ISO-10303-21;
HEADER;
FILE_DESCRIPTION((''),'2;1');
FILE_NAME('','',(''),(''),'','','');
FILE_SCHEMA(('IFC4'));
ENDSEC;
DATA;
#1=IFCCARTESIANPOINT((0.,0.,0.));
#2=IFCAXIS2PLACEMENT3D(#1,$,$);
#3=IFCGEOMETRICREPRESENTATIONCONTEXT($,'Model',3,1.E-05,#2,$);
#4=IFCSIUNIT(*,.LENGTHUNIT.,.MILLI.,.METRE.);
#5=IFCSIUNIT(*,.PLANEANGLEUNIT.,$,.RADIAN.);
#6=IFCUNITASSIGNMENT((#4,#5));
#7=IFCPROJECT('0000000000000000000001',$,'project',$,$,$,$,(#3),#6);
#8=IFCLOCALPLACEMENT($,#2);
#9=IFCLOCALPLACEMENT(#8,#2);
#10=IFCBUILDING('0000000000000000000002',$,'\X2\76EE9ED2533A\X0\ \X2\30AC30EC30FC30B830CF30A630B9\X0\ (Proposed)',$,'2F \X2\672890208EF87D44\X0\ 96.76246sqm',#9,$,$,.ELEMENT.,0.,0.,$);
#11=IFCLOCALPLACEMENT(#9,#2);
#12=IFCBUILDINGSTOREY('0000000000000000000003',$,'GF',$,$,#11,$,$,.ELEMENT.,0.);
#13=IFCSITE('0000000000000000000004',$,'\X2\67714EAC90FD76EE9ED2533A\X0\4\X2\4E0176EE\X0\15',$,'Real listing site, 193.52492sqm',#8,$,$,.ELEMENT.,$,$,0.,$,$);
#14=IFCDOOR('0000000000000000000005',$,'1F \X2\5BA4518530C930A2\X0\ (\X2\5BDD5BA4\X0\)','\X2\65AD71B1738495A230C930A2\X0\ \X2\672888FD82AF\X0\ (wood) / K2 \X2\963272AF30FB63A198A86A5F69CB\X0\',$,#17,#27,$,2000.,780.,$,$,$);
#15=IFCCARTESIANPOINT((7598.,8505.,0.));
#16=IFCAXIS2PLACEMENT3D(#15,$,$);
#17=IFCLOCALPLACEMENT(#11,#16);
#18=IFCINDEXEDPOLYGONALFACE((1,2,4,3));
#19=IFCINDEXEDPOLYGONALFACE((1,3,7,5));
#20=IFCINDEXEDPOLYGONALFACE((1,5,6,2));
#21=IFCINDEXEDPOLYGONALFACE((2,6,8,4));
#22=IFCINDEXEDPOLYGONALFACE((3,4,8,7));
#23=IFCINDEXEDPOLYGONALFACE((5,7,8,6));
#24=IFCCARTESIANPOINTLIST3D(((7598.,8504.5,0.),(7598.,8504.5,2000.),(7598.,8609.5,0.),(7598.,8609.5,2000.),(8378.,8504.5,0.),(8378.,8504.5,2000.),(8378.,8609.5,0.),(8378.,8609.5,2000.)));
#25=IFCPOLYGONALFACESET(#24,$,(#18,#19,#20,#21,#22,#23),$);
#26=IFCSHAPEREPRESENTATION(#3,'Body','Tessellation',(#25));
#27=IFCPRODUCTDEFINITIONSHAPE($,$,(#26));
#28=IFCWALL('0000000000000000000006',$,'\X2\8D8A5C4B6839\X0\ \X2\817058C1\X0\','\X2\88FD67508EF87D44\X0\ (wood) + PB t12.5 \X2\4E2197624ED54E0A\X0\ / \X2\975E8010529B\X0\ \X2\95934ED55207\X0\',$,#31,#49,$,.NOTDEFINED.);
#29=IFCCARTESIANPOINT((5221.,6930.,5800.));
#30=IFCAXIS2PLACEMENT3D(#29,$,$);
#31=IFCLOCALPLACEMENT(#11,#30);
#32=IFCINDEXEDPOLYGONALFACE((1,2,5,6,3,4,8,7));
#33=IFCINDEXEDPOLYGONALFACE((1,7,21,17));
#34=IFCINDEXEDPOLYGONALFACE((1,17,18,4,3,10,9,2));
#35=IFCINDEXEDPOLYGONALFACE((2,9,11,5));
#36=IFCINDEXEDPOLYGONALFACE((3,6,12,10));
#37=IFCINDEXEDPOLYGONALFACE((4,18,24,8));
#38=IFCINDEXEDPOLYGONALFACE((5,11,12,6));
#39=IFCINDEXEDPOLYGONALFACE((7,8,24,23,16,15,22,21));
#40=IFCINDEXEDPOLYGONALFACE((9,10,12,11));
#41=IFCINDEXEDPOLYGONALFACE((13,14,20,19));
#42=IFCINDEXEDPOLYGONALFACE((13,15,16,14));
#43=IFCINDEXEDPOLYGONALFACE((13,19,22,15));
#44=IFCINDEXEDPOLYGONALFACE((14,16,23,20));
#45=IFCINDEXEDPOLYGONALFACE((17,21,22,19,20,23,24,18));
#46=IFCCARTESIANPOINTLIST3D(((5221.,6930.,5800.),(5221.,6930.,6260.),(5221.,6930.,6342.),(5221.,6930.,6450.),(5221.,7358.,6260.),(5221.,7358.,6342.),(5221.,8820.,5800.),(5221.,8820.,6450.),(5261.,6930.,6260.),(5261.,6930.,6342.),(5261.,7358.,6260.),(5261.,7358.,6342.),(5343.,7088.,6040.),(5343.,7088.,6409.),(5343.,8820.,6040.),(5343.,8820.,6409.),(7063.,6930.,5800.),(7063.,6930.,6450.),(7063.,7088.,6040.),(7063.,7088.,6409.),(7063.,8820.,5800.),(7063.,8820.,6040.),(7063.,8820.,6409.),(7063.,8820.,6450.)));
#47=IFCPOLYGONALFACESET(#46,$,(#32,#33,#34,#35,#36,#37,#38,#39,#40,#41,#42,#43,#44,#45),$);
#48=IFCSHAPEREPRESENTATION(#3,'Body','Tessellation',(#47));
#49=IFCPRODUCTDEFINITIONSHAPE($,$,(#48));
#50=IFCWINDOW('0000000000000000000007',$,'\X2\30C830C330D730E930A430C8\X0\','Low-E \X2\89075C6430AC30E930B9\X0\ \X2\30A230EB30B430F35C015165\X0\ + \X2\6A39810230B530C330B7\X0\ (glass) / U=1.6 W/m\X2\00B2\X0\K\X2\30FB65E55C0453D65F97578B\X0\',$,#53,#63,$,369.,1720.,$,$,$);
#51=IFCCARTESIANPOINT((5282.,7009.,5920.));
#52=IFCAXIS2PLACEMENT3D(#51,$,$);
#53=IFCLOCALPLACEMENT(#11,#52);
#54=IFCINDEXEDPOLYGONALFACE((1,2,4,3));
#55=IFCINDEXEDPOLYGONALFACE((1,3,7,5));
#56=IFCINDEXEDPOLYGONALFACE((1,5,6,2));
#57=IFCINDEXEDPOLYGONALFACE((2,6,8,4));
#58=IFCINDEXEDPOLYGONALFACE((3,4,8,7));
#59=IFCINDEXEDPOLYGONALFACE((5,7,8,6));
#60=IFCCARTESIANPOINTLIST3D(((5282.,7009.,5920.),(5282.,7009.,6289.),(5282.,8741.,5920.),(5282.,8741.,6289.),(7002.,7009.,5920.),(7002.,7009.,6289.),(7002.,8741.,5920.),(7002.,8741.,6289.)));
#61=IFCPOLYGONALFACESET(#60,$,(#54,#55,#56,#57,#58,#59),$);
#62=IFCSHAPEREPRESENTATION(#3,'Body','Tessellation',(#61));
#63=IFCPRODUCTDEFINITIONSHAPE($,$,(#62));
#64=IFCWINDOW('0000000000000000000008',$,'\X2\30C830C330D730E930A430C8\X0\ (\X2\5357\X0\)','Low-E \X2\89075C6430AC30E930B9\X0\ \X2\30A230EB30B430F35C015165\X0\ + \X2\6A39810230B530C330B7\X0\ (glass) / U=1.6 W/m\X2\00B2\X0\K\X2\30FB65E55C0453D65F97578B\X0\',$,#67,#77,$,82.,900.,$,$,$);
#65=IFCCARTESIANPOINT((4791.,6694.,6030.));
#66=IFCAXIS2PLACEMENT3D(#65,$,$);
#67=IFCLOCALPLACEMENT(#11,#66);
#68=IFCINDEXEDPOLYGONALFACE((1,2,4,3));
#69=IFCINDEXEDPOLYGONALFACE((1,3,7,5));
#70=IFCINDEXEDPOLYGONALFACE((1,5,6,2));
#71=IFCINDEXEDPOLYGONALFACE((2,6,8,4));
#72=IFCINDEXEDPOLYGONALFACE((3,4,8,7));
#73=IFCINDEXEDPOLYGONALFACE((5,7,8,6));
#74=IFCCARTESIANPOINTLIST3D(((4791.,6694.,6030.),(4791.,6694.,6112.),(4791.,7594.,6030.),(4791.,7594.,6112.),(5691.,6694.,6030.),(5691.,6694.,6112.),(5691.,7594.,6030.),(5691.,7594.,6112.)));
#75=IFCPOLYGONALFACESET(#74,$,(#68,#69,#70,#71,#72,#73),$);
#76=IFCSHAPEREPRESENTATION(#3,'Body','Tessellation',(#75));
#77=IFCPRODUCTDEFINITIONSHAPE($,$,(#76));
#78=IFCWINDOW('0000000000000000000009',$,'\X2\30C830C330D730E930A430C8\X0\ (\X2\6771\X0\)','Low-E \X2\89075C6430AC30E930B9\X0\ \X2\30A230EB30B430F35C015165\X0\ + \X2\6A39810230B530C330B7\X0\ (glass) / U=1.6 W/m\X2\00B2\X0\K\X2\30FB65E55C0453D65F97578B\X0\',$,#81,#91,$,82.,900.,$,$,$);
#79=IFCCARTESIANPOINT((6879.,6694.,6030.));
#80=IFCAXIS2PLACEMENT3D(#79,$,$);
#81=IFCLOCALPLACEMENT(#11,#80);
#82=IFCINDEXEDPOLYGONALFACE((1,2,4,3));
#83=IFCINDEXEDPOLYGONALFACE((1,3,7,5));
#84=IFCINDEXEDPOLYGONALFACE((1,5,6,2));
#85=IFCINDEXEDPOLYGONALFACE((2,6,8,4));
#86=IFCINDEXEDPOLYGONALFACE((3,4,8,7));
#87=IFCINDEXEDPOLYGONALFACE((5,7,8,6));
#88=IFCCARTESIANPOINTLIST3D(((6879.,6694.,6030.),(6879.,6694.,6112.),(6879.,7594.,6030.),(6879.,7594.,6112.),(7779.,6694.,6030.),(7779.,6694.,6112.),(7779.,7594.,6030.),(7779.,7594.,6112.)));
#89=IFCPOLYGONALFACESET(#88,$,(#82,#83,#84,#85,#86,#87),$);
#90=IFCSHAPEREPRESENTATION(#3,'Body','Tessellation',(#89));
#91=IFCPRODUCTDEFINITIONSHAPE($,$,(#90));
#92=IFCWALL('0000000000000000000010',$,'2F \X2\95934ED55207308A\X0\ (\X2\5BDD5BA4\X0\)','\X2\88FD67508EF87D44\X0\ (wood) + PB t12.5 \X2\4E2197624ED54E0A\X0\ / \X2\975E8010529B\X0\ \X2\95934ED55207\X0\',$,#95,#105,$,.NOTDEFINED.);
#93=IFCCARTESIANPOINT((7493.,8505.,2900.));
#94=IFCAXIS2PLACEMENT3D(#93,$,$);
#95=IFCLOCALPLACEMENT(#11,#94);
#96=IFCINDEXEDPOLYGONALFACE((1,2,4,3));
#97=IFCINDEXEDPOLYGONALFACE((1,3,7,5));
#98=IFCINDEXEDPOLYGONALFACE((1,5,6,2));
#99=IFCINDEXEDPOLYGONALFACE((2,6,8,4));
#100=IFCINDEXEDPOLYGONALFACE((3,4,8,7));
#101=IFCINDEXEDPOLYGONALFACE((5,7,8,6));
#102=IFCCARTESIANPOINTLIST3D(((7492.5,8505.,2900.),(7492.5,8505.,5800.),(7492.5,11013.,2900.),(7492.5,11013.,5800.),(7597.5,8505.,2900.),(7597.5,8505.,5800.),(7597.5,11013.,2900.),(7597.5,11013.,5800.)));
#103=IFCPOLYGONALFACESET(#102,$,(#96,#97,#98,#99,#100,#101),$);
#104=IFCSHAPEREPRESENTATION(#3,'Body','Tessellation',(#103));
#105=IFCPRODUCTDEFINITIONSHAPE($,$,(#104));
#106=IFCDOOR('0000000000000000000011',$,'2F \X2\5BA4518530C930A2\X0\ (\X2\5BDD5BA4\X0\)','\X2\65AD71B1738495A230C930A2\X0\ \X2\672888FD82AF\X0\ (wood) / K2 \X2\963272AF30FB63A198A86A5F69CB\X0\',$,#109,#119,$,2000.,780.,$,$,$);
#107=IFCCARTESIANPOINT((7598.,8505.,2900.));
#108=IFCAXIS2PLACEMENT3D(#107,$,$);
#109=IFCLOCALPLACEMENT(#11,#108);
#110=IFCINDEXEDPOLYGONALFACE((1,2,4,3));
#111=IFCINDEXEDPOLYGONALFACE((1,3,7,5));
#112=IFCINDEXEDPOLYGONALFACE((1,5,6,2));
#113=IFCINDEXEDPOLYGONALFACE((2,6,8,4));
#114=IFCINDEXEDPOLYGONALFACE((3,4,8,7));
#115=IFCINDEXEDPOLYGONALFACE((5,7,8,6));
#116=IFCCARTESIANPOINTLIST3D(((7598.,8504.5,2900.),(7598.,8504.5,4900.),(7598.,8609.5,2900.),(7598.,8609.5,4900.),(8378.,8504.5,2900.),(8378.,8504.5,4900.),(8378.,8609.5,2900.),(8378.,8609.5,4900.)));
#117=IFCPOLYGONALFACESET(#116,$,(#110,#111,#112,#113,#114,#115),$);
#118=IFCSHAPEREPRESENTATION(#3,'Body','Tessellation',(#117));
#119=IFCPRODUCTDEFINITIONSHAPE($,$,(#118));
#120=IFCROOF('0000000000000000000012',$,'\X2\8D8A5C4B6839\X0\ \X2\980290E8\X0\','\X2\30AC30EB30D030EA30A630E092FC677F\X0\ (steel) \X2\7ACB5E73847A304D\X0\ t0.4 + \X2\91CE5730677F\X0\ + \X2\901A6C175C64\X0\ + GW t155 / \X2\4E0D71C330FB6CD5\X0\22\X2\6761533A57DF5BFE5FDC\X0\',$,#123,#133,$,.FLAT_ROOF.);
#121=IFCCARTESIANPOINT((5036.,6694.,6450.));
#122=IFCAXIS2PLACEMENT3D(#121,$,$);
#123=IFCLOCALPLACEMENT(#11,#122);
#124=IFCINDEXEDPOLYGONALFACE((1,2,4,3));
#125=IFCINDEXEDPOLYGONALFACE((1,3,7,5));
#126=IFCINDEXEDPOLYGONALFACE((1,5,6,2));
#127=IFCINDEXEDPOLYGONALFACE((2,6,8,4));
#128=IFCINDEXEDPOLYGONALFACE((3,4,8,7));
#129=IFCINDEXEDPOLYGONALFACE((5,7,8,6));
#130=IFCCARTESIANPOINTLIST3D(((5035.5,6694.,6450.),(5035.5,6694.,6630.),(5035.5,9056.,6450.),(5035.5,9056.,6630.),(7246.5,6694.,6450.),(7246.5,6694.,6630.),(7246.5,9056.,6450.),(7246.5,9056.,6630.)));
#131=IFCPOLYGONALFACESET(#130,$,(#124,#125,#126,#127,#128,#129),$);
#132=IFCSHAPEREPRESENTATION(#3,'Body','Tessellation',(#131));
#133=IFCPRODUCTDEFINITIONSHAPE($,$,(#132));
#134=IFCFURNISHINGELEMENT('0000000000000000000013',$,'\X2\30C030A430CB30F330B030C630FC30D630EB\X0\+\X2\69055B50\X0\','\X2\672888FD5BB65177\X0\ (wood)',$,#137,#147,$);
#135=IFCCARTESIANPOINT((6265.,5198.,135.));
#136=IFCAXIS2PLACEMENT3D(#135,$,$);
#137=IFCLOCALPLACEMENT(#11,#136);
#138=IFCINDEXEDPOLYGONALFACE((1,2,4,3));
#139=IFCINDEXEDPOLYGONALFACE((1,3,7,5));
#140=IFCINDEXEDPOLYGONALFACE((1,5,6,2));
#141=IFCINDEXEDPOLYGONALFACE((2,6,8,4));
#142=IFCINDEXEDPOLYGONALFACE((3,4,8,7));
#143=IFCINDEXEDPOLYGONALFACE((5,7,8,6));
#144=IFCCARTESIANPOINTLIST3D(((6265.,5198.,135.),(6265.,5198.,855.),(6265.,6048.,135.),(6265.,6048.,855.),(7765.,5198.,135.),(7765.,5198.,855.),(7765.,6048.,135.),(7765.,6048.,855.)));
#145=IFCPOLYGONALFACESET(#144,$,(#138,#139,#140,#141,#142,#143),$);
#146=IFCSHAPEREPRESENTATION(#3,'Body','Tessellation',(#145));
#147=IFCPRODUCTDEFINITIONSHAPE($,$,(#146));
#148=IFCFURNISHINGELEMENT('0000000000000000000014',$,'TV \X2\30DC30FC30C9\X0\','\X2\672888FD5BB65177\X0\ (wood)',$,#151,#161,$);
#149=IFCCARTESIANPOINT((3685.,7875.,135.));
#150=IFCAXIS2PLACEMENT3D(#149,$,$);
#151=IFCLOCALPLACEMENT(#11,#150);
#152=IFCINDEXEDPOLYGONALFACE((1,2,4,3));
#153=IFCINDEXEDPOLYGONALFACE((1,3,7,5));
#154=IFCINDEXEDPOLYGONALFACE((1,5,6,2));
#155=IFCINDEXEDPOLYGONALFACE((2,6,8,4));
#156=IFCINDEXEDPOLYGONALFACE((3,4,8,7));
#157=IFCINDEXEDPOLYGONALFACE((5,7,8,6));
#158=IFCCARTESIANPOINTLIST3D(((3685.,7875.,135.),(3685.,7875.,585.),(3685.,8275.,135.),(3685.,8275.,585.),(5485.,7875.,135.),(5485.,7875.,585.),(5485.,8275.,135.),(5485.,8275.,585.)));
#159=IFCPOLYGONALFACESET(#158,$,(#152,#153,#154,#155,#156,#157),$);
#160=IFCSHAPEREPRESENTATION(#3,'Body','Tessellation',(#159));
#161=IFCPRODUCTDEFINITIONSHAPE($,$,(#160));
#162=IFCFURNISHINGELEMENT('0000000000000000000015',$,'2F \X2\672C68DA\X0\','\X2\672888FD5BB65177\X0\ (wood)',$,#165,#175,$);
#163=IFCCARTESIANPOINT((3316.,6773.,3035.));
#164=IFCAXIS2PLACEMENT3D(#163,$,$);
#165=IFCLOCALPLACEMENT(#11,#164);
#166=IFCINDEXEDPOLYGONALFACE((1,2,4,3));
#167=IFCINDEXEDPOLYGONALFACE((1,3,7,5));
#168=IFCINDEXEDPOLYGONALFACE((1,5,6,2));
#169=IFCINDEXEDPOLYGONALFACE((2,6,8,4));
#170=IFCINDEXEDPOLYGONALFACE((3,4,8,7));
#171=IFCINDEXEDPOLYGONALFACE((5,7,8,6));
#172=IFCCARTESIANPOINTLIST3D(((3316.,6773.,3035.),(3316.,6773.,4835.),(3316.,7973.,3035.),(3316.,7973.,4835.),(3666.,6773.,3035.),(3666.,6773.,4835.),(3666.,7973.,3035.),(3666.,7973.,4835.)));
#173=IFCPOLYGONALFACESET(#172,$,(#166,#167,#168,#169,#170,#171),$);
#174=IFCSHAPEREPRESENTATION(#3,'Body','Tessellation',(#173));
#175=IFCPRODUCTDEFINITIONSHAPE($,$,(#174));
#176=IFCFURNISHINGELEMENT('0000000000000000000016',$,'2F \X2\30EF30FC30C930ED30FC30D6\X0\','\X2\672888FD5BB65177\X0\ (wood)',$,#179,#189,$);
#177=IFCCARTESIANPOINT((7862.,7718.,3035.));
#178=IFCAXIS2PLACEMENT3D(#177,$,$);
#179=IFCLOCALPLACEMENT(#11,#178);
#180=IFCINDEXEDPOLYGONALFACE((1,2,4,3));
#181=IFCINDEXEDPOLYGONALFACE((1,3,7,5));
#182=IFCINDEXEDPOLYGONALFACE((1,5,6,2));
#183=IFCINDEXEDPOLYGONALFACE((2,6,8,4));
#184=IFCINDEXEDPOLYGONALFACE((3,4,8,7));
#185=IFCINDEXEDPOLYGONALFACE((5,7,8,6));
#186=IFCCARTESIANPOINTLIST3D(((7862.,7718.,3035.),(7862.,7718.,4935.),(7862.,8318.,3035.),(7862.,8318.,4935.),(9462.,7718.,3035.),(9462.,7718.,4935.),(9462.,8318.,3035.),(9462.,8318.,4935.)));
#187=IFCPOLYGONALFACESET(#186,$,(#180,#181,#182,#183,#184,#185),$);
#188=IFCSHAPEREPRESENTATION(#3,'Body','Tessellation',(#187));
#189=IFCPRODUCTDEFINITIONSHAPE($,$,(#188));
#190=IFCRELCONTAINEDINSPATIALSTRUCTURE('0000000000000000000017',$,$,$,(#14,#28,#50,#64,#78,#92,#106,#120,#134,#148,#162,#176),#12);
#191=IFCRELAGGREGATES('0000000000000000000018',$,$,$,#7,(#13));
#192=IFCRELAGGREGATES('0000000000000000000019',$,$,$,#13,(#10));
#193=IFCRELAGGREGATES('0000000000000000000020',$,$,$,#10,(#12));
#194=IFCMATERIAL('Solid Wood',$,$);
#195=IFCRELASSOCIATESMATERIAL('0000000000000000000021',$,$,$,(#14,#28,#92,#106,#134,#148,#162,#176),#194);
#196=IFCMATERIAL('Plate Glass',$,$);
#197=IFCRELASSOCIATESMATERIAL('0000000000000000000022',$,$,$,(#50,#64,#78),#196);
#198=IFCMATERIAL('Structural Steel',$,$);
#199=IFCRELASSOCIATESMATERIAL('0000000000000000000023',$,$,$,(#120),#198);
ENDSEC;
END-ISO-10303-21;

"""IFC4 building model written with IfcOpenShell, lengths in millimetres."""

from ifc_helpers import new_model, si_unit, frame, frame_2d, origin, place, context, project, spatial, rectangle, extrude, material, element, fill, save


model = new_model("IFC4")

# Units and contexts
model_context = context("Model", 3, precision=1e-05, world=origin())
ifc_project = project(units=[si_unit("LENGTHUNIT", "METRE", prefix="MILLI"), si_unit("PLANEANGLEUNIT", "RADIAN")], contexts=[model_context])

# Site, building, storey
site_placement = place(None, origin())
site = spatial("IfcSite", under=ifc_project, at=site_placement, Name="東京都目黒区4丁目15", ObjectType="Real listing site, 193.52492sqm", CompositionType="ELEMENT", RefElevation=0.0)
building_placement = place(site_placement, origin())
building = spatial("IfcBuilding", under=site, at=building_placement, Name="目黒区 ガレージハウス (Proposed)", ObjectType="2F 木造軸組 96.76246sqm", CompositionType="ELEMENT", ElevationOfRefHeight=0.0, ElevationOfTerrain=0.0)
storey_placement = place(building_placement, origin())
storey = spatial("IfcBuildingStorey", under=building, at=storey_placement, Name="GF", CompositionType="ELEMENT", Elevation=0.0)

# Shared definitions
ifc_material_1 = material(Name="Solid Wood")

# Door
door_1_placement = place(storey_placement, frame((7598.0, 8505.0, 0.0)))
element("IfcDoor", 1, at=door_1_placement, inside=storey, material=ifc_material_1, Name="1F 室内ドア (寝室)", Description="断熱玄関ドア 木製芯 (wood) / K2 防犯・採風機構", OverallHeight=2000.0, OverallWidth=780.0, context=model_context, shape_type="SweptSolid", body=[
    extrude(rectangle(XDim=780.0, YDim=105.0, at=frame_2d((390.0, 52.0))), frame((7598.0, 8505.0, 0.0)), (0.0, 0.0, 1.0), 2000.0),
])

# Wall, openings, windows
wall_1_placement = place(storey_placement, frame((5221.0, 6930.0, 5800.0)))
wall_1 = element("IfcWall", 2, at=wall_1_placement, inside=storey, material=ifc_material_1, Name="越屋根 腰壁", Description="製材軸組 (wood) + PB t12.5 両面仕上 / 非耐力 間仕切", PredefinedType="NOTDEFINED", context=model_context, shape_type="SweptSolid", body=[
    extrude(rectangle(XDim=1842.0, YDim=1890.0, at=frame_2d((921.0, 945.0))), frame((5221.0, 6930.0, 5800.0)), (0.0, 0.0, 1.0), 650.0),
])
opening_1_placement = place(storey_placement, frame((5282.0, 7009.0, 5920.0)))
opening_1 = element("IfcOpeningElement", 3, at=opening_1_placement, cuts=wall_1, PredefinedType="NOTDEFINED", context=model_context, shape_type="SweptSolid", body=[
    extrude(rectangle(XDim=1720.0, YDim=1732.0, at=frame_2d((860.0, 866.0))), frame((5282.0, 7009.0, 5920.0)), (0.0, 0.0, 1.0), 369.0),
])
opening_2_placement = place(storey_placement, frame((4791.0, 6694.0, 6030.0)))
opening_2 = element("IfcOpeningElement", 4, at=opening_2_placement, cuts=wall_1, PredefinedType="NOTDEFINED", context=model_context, shape_type="SweptSolid", body=[
    extrude(rectangle(XDim=900.0, YDim=900.0, at=frame_2d((450.0, 450.0))), frame((4791.0, 6694.0, 6030.0)), (0.0, 0.0, 1.0), 82.0),
])
opening_3_placement = place(storey_placement, frame((6879.0, 6694.0, 6030.0)))
opening_3 = element("IfcOpeningElement", 5, at=opening_3_placement, cuts=wall_1, PredefinedType="NOTDEFINED", context=model_context, shape_type="SweptSolid", body=[
    extrude(rectangle(XDim=900.0, YDim=900.0, at=frame_2d((450.0, 450.0))), frame((6879.0, 6694.0, 6030.0)), (0.0, 0.0, 1.0), 82.0),
])
ifc_material_2 = material(Name="Plate Glass")
window_1_placement = place(storey_placement, frame((5282.0, 7009.0, 5920.0)))
window_1 = element("IfcWindow", 6, at=window_1_placement, inside=storey, material=ifc_material_2, Name="トップライト", Description="Low-E 複層ガラス アルゴン封入 + 樹脂サッシ (glass) / U=1.6 W/m²K・日射取得型", OverallHeight=369.0, OverallWidth=1720.0, context=model_context, shape_type="SweptSolid", body=[
    extrude(rectangle(XDim=1720.0, YDim=1732.0, at=frame_2d((860.0, 866.0))), frame((5282.0, 7009.0, 5920.0)), (0.0, 0.0, 1.0), 369.0),
])
fill(opening_1, window_1)
window_2_placement = place(storey_placement, frame((4791.0, 6694.0, 6030.0)))
window_2 = element("IfcWindow", 7, at=window_2_placement, inside=storey, material=ifc_material_2, Name="トップライト (南)", Description="Low-E 複層ガラス アルゴン封入 + 樹脂サッシ (glass) / U=1.6 W/m²K・日射取得型", OverallHeight=82.0, OverallWidth=900.0, context=model_context, shape_type="SweptSolid", body=[
    extrude(rectangle(XDim=900.0, YDim=900.0, at=frame_2d((450.0, 450.0))), frame((4791.0, 6694.0, 6030.0)), (0.0, 0.0, 1.0), 82.0),
])
fill(opening_2, window_2)
window_3_placement = place(storey_placement, frame((6879.0, 6694.0, 6030.0)))
window_3 = element("IfcWindow", 8, at=window_3_placement, inside=storey, material=ifc_material_2, Name="トップライト (東)", Description="Low-E 複層ガラス アルゴン封入 + 樹脂サッシ (glass) / U=1.6 W/m²K・日射取得型", OverallHeight=82.0, OverallWidth=900.0, context=model_context, shape_type="SweptSolid", body=[
    extrude(rectangle(XDim=900.0, YDim=900.0, at=frame_2d((450.0, 450.0))), frame((6879.0, 6694.0, 6030.0)), (0.0, 0.0, 1.0), 82.0),
])
fill(opening_3, window_3)

# Wall
wall_2_placement = place(storey_placement, frame((7493.0, 8505.0, 2900.0)))
element("IfcWall", 9, at=wall_2_placement, inside=storey, material=ifc_material_1, Name="2F 間仕切り (寝室)", Description="製材軸組 (wood) + PB t12.5 両面仕上 / 非耐力 間仕切", PredefinedType="NOTDEFINED", context=model_context, shape_type="SweptSolid", body=[
    extrude(rectangle(XDim=105.0, YDim=2508.0, at=frame_2d((52.0, 1254.0))), frame((7493.0, 8505.0, 2900.0)), (0.0, 0.0, 1.0), 2900.0),
])

# Door
door_2_placement = place(storey_placement, frame((7598.0, 8505.0, 2900.0)))
element("IfcDoor", 10, at=door_2_placement, inside=storey, material=ifc_material_1, Name="2F 室内ドア (寝室)", Description="断熱玄関ドア 木製芯 (wood) / K2 防犯・採風機構", OverallHeight=2000.0, OverallWidth=780.0, context=model_context, shape_type="SweptSolid", body=[
    extrude(rectangle(XDim=780.0, YDim=105.0, at=frame_2d((390.0, 52.0))), frame((7598.0, 8505.0, 2900.0)), (0.0, 0.0, 1.0), 2000.0),
])

# Roof
ifc_material_3 = material(Name="Structural Steel")
roof_placement = place(storey_placement, frame((5036.0, 6694.0, 6450.0)))
element("IfcRoof", 11, at=roof_placement, inside=storey, material=ifc_material_3, Name="越屋根 頂部", Description="ガルバリウム鋼板 (steel) 立平葺き t0.4 + 野地板 + 通気層 + GW t155 / 不燃・法22条区域対応", PredefinedType="FLAT_ROOF", context=model_context, shape_type="SweptSolid", body=[
    extrude(rectangle(XDim=2211.0, YDim=2362.0, at=frame_2d((1105.0, 1181.0))), frame((5036.0, 6694.0, 6450.0)), (0.0, 0.0, 1.0), 180.0),
])

# Furnishing elements
furnishing_1_placement = place(storey_placement, frame((6265.0, 5198.0, 135.0)))
element("IfcFurnishingElement", 12, at=furnishing_1_placement, inside=storey, material=ifc_material_1, Name="ダイニングテーブル+椅子", Description="木製家具 (wood)", context=model_context, shape_type="SweptSolid", body=[
    extrude(rectangle(XDim=1500.0, YDim=850.0, at=frame_2d((750.0, 425.0))), frame((6265.0, 5198.0, 135.0)), (0.0, 0.0, 1.0), 720.0),
])
furnishing_2_placement = place(storey_placement, frame((3685.0, 7875.0, 135.0)))
element("IfcFurnishingElement", 13, at=furnishing_2_placement, inside=storey, material=ifc_material_1, Name="TV ボード", Description="木製家具 (wood)", context=model_context, shape_type="SweptSolid", body=[
    extrude(rectangle(XDim=1800.0, YDim=400.0, at=frame_2d((900.0, 200.0))), frame((3685.0, 7875.0, 135.0)), (0.0, 0.0, 1.0), 450.0),
])
furnishing_3_placement = place(storey_placement, frame((3316.0, 6773.0, 3035.0)))
element("IfcFurnishingElement", 14, at=furnishing_3_placement, inside=storey, material=ifc_material_1, Name="2F 本棚", Description="木製家具 (wood)", context=model_context, shape_type="SweptSolid", body=[
    extrude(rectangle(XDim=350.0, YDim=1200.0, at=frame_2d((175.0, 600.0))), frame((3316.0, 6773.0, 3035.0)), (0.0, 0.0, 1.0), 1800.0),
])
furnishing_4_placement = place(storey_placement, frame((7862.0, 7718.0, 3035.0)))
element("IfcFurnishingElement", 15, at=furnishing_4_placement, inside=storey, material=ifc_material_1, Name="2F ワードローブ", Description="木製家具 (wood)", context=model_context, shape_type="SweptSolid", body=[
    extrude(rectangle(XDim=1600.0, YDim=600.0, at=frame_2d((800.0, 300.0))), frame((7862.0, 7718.0, 3035.0)), (0.0, 0.0, 1.0), 1900.0),
])

save(model, "model.ifc")
